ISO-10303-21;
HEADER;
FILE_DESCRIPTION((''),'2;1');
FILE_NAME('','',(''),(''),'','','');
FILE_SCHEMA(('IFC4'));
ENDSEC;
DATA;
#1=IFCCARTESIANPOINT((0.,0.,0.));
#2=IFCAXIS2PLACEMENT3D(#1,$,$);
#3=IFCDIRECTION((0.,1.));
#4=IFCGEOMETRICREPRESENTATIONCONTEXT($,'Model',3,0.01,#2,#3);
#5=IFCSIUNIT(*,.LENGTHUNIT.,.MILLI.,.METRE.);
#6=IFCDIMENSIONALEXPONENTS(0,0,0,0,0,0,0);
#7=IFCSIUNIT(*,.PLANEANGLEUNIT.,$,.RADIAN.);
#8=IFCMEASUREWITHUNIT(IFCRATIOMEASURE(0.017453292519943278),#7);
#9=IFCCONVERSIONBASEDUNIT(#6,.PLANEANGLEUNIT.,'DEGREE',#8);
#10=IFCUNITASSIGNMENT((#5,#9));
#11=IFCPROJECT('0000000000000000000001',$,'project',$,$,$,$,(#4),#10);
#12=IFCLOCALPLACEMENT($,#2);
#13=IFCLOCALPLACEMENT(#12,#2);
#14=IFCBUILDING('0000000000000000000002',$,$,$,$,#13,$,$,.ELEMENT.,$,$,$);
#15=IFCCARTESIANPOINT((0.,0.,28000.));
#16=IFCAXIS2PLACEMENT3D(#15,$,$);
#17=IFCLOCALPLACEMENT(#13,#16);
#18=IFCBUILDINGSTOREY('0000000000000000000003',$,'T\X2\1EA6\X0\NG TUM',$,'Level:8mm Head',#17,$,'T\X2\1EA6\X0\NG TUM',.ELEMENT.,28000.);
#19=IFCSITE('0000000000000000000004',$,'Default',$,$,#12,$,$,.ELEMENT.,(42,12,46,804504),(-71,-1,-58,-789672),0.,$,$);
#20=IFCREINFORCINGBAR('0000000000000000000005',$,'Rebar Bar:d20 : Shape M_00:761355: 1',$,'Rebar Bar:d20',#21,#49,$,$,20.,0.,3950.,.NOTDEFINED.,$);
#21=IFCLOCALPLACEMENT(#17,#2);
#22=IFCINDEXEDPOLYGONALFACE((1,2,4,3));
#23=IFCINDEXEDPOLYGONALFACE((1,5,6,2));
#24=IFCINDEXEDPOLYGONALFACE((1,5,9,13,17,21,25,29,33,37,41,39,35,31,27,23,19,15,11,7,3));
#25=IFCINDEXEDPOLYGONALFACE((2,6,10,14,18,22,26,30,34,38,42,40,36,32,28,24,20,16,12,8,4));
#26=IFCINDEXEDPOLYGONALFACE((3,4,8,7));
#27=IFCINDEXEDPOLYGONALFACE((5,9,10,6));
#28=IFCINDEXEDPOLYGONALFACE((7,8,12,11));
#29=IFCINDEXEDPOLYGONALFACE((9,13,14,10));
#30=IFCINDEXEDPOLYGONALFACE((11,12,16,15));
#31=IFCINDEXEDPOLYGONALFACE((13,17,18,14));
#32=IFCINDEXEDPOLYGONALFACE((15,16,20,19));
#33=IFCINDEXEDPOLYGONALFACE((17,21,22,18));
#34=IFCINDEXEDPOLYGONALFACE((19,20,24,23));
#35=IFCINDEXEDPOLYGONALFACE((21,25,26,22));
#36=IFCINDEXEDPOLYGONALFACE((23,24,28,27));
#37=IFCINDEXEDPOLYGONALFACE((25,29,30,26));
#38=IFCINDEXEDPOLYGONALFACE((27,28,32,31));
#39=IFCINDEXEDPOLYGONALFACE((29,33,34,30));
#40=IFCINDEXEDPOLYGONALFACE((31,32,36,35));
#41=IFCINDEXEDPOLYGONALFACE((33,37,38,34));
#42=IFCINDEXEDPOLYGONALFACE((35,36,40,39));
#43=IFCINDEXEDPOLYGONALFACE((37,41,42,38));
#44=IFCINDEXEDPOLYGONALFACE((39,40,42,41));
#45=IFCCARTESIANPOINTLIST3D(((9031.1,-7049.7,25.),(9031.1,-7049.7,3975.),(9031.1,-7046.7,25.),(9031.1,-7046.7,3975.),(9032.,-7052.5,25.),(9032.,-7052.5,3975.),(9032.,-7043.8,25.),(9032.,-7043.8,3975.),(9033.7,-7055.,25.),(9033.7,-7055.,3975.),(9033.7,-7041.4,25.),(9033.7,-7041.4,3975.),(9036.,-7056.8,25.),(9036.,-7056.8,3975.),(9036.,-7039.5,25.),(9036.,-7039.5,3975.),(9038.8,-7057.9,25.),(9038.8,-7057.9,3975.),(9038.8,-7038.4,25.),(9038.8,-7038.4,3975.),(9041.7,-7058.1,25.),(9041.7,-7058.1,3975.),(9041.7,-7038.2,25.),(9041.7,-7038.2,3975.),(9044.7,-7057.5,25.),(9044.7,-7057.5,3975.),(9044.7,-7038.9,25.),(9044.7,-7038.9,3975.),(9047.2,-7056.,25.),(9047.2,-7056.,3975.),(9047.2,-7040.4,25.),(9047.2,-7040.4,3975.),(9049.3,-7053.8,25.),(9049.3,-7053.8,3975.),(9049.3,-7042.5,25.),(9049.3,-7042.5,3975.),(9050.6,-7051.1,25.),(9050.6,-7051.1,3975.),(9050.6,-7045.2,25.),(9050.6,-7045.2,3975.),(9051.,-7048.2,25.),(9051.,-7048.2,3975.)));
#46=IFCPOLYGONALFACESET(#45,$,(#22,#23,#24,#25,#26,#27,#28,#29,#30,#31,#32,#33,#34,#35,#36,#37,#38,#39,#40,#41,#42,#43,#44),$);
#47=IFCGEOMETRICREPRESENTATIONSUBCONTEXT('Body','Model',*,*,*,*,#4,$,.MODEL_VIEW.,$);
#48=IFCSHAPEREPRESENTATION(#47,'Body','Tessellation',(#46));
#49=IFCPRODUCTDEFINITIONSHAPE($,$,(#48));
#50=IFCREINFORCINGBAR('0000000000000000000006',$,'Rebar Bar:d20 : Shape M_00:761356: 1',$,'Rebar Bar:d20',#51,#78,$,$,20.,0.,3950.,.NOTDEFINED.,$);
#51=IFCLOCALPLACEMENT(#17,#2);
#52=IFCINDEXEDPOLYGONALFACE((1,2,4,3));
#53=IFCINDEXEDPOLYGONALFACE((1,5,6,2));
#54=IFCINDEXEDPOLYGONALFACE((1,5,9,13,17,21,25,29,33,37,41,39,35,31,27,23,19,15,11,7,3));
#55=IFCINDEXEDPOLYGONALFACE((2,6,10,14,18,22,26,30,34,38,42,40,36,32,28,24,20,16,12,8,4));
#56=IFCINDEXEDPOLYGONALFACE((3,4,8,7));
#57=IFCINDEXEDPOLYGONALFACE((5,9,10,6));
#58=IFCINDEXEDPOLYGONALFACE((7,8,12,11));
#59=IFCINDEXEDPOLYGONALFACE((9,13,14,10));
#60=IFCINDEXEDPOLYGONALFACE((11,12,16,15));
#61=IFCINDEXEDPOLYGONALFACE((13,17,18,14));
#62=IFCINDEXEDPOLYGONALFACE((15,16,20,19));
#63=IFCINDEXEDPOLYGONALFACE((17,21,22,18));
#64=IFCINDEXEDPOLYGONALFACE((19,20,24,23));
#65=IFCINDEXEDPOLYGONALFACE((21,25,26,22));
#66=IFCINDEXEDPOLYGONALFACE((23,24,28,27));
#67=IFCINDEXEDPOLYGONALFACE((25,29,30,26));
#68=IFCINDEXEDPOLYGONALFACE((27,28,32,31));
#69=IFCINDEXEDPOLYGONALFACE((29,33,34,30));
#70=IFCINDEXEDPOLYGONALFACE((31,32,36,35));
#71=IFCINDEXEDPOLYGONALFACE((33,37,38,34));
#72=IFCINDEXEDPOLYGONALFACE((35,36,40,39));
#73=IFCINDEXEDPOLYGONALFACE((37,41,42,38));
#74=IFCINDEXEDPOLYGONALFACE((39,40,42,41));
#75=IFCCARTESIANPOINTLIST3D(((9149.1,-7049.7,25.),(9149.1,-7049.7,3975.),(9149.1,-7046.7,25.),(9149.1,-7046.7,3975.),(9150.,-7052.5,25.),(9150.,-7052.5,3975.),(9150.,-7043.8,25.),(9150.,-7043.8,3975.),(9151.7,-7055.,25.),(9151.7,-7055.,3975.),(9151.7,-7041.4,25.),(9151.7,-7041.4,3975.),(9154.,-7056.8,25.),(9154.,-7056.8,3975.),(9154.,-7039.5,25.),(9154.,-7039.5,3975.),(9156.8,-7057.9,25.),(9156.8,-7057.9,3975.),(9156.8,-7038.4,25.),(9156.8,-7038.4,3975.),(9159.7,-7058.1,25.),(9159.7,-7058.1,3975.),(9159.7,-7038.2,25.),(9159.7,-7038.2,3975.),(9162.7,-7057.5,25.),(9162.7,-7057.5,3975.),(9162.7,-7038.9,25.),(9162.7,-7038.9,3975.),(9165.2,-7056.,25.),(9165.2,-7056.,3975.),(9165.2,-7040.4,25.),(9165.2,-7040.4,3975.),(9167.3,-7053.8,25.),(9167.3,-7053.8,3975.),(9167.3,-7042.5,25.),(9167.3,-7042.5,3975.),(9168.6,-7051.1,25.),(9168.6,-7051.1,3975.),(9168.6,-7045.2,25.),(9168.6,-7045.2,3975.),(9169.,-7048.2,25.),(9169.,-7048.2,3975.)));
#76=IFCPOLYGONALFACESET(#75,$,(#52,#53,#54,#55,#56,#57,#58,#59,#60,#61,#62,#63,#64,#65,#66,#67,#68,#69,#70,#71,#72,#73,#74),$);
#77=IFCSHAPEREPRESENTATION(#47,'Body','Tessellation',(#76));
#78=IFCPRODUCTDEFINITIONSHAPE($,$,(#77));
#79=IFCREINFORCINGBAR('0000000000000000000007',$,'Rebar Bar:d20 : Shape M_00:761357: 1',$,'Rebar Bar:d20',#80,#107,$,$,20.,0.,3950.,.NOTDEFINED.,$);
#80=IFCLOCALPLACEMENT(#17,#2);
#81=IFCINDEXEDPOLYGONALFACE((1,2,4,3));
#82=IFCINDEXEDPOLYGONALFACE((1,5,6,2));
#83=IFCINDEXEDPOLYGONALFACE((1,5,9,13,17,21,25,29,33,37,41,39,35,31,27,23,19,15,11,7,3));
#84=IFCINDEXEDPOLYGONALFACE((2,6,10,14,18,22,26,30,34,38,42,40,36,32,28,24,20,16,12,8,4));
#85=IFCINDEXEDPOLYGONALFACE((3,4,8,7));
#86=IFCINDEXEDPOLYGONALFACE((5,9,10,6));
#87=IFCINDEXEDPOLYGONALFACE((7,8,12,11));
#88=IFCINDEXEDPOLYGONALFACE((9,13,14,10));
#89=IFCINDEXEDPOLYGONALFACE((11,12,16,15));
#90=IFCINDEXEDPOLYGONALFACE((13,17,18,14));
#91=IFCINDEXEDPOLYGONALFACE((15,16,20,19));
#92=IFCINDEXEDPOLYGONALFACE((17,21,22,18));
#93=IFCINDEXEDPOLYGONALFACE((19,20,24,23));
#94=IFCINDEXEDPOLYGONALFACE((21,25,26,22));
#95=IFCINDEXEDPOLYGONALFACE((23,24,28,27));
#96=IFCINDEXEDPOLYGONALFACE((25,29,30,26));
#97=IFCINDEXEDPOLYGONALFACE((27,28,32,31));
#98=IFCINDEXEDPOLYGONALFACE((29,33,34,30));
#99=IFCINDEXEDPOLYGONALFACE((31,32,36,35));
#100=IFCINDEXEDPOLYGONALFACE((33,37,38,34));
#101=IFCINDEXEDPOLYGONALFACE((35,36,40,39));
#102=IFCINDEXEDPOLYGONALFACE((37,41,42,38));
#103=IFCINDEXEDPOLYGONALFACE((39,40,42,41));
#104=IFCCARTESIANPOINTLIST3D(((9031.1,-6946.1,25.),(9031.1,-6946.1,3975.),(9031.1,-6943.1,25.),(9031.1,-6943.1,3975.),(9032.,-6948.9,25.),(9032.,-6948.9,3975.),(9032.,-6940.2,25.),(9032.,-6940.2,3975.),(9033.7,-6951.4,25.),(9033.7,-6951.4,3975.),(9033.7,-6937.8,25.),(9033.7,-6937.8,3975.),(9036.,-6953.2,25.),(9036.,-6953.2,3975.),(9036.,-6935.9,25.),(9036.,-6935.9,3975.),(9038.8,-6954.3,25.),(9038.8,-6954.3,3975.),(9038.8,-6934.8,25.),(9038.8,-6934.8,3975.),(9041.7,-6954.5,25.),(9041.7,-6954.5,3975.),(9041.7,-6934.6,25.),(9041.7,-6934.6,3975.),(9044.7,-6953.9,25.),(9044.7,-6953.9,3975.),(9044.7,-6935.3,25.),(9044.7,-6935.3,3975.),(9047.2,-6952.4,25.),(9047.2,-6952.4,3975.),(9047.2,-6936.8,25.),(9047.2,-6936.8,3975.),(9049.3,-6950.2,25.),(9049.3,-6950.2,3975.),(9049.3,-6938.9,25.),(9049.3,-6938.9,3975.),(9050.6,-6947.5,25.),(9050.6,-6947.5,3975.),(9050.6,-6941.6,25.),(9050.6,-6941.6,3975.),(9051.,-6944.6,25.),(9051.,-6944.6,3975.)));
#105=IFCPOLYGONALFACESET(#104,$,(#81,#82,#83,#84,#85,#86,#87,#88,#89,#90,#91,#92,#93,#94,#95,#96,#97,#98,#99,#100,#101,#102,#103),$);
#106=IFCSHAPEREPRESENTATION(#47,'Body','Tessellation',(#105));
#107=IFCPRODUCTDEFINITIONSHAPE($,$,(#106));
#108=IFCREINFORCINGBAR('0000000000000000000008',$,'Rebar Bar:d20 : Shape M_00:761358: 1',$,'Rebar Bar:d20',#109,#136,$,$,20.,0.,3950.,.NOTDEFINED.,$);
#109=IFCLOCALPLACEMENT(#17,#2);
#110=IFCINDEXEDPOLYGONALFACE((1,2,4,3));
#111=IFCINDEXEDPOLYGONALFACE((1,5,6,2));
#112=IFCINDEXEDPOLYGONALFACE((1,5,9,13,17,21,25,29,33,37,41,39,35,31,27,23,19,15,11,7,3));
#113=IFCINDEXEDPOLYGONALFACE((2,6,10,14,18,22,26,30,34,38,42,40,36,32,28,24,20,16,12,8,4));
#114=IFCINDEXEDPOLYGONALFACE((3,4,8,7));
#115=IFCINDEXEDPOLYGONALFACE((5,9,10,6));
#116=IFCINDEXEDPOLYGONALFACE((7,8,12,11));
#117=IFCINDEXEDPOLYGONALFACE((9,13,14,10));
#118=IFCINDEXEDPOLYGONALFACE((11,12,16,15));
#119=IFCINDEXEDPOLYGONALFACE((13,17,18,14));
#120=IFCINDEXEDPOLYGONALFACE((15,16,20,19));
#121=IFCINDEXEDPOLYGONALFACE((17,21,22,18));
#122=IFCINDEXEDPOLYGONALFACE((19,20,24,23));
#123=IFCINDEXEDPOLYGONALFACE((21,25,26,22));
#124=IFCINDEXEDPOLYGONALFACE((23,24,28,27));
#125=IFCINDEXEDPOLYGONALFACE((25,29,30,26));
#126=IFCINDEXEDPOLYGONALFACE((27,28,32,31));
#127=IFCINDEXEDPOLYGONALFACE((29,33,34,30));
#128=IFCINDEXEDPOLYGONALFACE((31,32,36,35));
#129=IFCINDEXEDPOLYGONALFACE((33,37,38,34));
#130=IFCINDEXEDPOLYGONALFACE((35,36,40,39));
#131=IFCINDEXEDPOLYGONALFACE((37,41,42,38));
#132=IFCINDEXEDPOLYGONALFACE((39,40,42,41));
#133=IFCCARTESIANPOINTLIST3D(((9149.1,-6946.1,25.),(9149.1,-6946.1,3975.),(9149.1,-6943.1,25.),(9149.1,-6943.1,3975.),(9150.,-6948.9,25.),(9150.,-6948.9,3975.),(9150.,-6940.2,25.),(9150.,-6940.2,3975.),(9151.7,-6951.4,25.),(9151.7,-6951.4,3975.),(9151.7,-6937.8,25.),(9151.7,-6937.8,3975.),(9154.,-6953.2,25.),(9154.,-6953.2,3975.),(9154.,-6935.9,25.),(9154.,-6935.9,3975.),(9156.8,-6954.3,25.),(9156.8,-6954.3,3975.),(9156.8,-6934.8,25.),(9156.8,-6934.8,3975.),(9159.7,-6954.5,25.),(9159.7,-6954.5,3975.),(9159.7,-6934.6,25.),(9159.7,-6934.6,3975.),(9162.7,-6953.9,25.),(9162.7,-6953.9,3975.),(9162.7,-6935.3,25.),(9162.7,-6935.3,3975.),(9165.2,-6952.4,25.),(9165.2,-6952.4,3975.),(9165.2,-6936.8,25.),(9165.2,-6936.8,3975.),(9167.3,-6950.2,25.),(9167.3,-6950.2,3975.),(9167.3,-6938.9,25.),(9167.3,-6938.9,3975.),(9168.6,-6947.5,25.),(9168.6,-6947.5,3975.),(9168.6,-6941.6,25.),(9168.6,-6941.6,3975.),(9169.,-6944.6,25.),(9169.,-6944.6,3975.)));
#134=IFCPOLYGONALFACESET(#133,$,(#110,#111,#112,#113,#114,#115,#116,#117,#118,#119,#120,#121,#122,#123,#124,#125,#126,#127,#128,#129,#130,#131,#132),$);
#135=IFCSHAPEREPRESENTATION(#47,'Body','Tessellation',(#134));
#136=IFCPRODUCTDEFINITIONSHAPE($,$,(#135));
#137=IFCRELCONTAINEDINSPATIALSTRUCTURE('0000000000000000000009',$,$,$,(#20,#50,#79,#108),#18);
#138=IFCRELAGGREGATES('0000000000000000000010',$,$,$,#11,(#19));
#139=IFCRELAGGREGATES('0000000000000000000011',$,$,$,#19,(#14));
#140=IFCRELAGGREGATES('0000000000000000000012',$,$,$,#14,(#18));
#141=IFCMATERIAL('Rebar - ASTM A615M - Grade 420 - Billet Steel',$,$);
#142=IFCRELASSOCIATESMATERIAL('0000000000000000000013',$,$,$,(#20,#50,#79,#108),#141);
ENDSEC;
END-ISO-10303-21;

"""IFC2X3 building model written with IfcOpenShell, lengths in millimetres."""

from ifc_helpers import new_model, entity, si_unit, converted_unit, direction, frame, origin, place, context, subcontext, project, spatial, material, element, save


model = new_model("IFC2X3")

# Units and contexts
model_context = context("Model", 3, precision=0.01, world=origin(), true_north=direction((0.0, 1.0)))
body_context = subcontext(model_context, "Body", "Model", "MODEL_VIEW")
ifc_project = project(units=[si_unit("LENGTHUNIT", "METRE", prefix="MILLI"), converted_unit("PLANEANGLEUNIT", "DEGREE", entity("IfcRatioMeasure", 0.017453292519943278), si_unit("PLANEANGLEUNIT", "RADIAN"), dimensions=[0, 0, 0, 0, 0, 0, 0])], contexts=[model_context])

# Site, building, storey
site_placement = place(None, origin())
site = spatial("IfcSite", under=ifc_project, at=site_placement, Name="Default", CompositionType="ELEMENT", RefLatitude=(42, 12, 46, 804504), RefLongitude=(-71, -1, -58, -789672), RefElevation=0.0)
building_placement = place(site_placement, origin())
building = spatial("IfcBuilding", under=site, at=building_placement, CompositionType="ELEMENT")
storey_placement = place(building_placement, frame((0.0, 0.0, 28000.0)))
storey = spatial("IfcBuildingStorey", under=building, at=storey_placement, Name="TẦNG TUM", ObjectType="Level:8mm Head", LongName="TẦNG TUM", CompositionType="ELEMENT", Elevation=28000.0)

# Reinforcing bars
ifc_material = material(Name="Rebar - ASTM A615M - Grade 420 - Billet Steel")
reinforcing_bar_1_placement = place(storey_placement, origin())
element("IfcReinforcingBar", 1, at=reinforcing_bar_1_placement, inside=storey, material=ifc_material, Name="Rebar Bar:d20 : Shape M_00:761355: 1", ObjectType="Rebar Bar:d20", BarLength=3950.0, BarRole="NOTDEFINED", CrossSectionArea=0.0, NominalDiameter=20.0, context=body_context, shape_type="AdvancedSweptSolid", body=[
    entity("IfcSweptDiskSolid", entity("IfcCompositeCurve", [entity("IfcCompositeCurveSegment", "CONTINUOUS", True, entity("IfcPolyline", [entity("IfcCartesianPoint", [9041.0, -7048.2, 25.0]), entity("IfcCartesianPoint", [9041.0, -7048.2, 3975.0])]))], False), 10.0, None, 0.0, 1.0),
])
reinforcing_bar_2_placement = place(storey_placement, origin())
element("IfcReinforcingBar", 2, at=reinforcing_bar_2_placement, inside=storey, material=ifc_material, Name="Rebar Bar:d20 : Shape M_00:761356: 1", ObjectType="Rebar Bar:d20", BarLength=3950.0, BarRole="NOTDEFINED", CrossSectionArea=0.0, NominalDiameter=20.0, context=body_context, shape_type="AdvancedSweptSolid", body=[
    entity("IfcSweptDiskSolid", entity("IfcCompositeCurve", [entity("IfcCompositeCurveSegment", "CONTINUOUS", True, entity("IfcPolyline", [entity("IfcCartesianPoint", [9159.0, -7048.2, 25.0]), entity("IfcCartesianPoint", [9159.0, -7048.2, 3975.0])]))], False), 10.0, None, 0.0, 1.0),
])
reinforcing_bar_3_placement = place(storey_placement, origin())
element("IfcReinforcingBar", 3, at=reinforcing_bar_3_placement, inside=storey, material=ifc_material, Name="Rebar Bar:d20 : Shape M_00:761357: 1", ObjectType="Rebar Bar:d20", BarLength=3950.0, BarRole="NOTDEFINED", CrossSectionArea=0.0, NominalDiameter=20.0, context=body_context, shape_type="AdvancedSweptSolid", body=[
    entity("IfcSweptDiskSolid", entity("IfcCompositeCurve", [entity("IfcCompositeCurveSegment", "CONTINUOUS", True, entity("IfcPolyline", [entity("IfcCartesianPoint", [9041.0, -6944.6, 25.0]), entity("IfcCartesianPoint", [9041.0, -6944.6, 3975.0])]))], False), 10.0, None, 0.0, 1.0),
])
reinforcing_bar_4_placement = place(storey_placement, origin())
element("IfcReinforcingBar", 4, at=reinforcing_bar_4_placement, inside=storey, material=ifc_material, Name="Rebar Bar:d20 : Shape M_00:761358: 1", ObjectType="Rebar Bar:d20", BarLength=3950.0, BarRole="NOTDEFINED", CrossSectionArea=0.0, NominalDiameter=20.0, context=body_context, shape_type="AdvancedSweptSolid", body=[
    entity("IfcSweptDiskSolid", entity("IfcCompositeCurve", [entity("IfcCompositeCurveSegment", "CONTINUOUS", True, entity("IfcPolyline", [entity("IfcCartesianPoint", [9159.0, -6944.6, 25.0]), entity("IfcCartesianPoint", [9159.0, -6944.6, 3975.0])]))], False), 10.0, None, 0.0, 1.0),
])

save(model, "model.ifc")
